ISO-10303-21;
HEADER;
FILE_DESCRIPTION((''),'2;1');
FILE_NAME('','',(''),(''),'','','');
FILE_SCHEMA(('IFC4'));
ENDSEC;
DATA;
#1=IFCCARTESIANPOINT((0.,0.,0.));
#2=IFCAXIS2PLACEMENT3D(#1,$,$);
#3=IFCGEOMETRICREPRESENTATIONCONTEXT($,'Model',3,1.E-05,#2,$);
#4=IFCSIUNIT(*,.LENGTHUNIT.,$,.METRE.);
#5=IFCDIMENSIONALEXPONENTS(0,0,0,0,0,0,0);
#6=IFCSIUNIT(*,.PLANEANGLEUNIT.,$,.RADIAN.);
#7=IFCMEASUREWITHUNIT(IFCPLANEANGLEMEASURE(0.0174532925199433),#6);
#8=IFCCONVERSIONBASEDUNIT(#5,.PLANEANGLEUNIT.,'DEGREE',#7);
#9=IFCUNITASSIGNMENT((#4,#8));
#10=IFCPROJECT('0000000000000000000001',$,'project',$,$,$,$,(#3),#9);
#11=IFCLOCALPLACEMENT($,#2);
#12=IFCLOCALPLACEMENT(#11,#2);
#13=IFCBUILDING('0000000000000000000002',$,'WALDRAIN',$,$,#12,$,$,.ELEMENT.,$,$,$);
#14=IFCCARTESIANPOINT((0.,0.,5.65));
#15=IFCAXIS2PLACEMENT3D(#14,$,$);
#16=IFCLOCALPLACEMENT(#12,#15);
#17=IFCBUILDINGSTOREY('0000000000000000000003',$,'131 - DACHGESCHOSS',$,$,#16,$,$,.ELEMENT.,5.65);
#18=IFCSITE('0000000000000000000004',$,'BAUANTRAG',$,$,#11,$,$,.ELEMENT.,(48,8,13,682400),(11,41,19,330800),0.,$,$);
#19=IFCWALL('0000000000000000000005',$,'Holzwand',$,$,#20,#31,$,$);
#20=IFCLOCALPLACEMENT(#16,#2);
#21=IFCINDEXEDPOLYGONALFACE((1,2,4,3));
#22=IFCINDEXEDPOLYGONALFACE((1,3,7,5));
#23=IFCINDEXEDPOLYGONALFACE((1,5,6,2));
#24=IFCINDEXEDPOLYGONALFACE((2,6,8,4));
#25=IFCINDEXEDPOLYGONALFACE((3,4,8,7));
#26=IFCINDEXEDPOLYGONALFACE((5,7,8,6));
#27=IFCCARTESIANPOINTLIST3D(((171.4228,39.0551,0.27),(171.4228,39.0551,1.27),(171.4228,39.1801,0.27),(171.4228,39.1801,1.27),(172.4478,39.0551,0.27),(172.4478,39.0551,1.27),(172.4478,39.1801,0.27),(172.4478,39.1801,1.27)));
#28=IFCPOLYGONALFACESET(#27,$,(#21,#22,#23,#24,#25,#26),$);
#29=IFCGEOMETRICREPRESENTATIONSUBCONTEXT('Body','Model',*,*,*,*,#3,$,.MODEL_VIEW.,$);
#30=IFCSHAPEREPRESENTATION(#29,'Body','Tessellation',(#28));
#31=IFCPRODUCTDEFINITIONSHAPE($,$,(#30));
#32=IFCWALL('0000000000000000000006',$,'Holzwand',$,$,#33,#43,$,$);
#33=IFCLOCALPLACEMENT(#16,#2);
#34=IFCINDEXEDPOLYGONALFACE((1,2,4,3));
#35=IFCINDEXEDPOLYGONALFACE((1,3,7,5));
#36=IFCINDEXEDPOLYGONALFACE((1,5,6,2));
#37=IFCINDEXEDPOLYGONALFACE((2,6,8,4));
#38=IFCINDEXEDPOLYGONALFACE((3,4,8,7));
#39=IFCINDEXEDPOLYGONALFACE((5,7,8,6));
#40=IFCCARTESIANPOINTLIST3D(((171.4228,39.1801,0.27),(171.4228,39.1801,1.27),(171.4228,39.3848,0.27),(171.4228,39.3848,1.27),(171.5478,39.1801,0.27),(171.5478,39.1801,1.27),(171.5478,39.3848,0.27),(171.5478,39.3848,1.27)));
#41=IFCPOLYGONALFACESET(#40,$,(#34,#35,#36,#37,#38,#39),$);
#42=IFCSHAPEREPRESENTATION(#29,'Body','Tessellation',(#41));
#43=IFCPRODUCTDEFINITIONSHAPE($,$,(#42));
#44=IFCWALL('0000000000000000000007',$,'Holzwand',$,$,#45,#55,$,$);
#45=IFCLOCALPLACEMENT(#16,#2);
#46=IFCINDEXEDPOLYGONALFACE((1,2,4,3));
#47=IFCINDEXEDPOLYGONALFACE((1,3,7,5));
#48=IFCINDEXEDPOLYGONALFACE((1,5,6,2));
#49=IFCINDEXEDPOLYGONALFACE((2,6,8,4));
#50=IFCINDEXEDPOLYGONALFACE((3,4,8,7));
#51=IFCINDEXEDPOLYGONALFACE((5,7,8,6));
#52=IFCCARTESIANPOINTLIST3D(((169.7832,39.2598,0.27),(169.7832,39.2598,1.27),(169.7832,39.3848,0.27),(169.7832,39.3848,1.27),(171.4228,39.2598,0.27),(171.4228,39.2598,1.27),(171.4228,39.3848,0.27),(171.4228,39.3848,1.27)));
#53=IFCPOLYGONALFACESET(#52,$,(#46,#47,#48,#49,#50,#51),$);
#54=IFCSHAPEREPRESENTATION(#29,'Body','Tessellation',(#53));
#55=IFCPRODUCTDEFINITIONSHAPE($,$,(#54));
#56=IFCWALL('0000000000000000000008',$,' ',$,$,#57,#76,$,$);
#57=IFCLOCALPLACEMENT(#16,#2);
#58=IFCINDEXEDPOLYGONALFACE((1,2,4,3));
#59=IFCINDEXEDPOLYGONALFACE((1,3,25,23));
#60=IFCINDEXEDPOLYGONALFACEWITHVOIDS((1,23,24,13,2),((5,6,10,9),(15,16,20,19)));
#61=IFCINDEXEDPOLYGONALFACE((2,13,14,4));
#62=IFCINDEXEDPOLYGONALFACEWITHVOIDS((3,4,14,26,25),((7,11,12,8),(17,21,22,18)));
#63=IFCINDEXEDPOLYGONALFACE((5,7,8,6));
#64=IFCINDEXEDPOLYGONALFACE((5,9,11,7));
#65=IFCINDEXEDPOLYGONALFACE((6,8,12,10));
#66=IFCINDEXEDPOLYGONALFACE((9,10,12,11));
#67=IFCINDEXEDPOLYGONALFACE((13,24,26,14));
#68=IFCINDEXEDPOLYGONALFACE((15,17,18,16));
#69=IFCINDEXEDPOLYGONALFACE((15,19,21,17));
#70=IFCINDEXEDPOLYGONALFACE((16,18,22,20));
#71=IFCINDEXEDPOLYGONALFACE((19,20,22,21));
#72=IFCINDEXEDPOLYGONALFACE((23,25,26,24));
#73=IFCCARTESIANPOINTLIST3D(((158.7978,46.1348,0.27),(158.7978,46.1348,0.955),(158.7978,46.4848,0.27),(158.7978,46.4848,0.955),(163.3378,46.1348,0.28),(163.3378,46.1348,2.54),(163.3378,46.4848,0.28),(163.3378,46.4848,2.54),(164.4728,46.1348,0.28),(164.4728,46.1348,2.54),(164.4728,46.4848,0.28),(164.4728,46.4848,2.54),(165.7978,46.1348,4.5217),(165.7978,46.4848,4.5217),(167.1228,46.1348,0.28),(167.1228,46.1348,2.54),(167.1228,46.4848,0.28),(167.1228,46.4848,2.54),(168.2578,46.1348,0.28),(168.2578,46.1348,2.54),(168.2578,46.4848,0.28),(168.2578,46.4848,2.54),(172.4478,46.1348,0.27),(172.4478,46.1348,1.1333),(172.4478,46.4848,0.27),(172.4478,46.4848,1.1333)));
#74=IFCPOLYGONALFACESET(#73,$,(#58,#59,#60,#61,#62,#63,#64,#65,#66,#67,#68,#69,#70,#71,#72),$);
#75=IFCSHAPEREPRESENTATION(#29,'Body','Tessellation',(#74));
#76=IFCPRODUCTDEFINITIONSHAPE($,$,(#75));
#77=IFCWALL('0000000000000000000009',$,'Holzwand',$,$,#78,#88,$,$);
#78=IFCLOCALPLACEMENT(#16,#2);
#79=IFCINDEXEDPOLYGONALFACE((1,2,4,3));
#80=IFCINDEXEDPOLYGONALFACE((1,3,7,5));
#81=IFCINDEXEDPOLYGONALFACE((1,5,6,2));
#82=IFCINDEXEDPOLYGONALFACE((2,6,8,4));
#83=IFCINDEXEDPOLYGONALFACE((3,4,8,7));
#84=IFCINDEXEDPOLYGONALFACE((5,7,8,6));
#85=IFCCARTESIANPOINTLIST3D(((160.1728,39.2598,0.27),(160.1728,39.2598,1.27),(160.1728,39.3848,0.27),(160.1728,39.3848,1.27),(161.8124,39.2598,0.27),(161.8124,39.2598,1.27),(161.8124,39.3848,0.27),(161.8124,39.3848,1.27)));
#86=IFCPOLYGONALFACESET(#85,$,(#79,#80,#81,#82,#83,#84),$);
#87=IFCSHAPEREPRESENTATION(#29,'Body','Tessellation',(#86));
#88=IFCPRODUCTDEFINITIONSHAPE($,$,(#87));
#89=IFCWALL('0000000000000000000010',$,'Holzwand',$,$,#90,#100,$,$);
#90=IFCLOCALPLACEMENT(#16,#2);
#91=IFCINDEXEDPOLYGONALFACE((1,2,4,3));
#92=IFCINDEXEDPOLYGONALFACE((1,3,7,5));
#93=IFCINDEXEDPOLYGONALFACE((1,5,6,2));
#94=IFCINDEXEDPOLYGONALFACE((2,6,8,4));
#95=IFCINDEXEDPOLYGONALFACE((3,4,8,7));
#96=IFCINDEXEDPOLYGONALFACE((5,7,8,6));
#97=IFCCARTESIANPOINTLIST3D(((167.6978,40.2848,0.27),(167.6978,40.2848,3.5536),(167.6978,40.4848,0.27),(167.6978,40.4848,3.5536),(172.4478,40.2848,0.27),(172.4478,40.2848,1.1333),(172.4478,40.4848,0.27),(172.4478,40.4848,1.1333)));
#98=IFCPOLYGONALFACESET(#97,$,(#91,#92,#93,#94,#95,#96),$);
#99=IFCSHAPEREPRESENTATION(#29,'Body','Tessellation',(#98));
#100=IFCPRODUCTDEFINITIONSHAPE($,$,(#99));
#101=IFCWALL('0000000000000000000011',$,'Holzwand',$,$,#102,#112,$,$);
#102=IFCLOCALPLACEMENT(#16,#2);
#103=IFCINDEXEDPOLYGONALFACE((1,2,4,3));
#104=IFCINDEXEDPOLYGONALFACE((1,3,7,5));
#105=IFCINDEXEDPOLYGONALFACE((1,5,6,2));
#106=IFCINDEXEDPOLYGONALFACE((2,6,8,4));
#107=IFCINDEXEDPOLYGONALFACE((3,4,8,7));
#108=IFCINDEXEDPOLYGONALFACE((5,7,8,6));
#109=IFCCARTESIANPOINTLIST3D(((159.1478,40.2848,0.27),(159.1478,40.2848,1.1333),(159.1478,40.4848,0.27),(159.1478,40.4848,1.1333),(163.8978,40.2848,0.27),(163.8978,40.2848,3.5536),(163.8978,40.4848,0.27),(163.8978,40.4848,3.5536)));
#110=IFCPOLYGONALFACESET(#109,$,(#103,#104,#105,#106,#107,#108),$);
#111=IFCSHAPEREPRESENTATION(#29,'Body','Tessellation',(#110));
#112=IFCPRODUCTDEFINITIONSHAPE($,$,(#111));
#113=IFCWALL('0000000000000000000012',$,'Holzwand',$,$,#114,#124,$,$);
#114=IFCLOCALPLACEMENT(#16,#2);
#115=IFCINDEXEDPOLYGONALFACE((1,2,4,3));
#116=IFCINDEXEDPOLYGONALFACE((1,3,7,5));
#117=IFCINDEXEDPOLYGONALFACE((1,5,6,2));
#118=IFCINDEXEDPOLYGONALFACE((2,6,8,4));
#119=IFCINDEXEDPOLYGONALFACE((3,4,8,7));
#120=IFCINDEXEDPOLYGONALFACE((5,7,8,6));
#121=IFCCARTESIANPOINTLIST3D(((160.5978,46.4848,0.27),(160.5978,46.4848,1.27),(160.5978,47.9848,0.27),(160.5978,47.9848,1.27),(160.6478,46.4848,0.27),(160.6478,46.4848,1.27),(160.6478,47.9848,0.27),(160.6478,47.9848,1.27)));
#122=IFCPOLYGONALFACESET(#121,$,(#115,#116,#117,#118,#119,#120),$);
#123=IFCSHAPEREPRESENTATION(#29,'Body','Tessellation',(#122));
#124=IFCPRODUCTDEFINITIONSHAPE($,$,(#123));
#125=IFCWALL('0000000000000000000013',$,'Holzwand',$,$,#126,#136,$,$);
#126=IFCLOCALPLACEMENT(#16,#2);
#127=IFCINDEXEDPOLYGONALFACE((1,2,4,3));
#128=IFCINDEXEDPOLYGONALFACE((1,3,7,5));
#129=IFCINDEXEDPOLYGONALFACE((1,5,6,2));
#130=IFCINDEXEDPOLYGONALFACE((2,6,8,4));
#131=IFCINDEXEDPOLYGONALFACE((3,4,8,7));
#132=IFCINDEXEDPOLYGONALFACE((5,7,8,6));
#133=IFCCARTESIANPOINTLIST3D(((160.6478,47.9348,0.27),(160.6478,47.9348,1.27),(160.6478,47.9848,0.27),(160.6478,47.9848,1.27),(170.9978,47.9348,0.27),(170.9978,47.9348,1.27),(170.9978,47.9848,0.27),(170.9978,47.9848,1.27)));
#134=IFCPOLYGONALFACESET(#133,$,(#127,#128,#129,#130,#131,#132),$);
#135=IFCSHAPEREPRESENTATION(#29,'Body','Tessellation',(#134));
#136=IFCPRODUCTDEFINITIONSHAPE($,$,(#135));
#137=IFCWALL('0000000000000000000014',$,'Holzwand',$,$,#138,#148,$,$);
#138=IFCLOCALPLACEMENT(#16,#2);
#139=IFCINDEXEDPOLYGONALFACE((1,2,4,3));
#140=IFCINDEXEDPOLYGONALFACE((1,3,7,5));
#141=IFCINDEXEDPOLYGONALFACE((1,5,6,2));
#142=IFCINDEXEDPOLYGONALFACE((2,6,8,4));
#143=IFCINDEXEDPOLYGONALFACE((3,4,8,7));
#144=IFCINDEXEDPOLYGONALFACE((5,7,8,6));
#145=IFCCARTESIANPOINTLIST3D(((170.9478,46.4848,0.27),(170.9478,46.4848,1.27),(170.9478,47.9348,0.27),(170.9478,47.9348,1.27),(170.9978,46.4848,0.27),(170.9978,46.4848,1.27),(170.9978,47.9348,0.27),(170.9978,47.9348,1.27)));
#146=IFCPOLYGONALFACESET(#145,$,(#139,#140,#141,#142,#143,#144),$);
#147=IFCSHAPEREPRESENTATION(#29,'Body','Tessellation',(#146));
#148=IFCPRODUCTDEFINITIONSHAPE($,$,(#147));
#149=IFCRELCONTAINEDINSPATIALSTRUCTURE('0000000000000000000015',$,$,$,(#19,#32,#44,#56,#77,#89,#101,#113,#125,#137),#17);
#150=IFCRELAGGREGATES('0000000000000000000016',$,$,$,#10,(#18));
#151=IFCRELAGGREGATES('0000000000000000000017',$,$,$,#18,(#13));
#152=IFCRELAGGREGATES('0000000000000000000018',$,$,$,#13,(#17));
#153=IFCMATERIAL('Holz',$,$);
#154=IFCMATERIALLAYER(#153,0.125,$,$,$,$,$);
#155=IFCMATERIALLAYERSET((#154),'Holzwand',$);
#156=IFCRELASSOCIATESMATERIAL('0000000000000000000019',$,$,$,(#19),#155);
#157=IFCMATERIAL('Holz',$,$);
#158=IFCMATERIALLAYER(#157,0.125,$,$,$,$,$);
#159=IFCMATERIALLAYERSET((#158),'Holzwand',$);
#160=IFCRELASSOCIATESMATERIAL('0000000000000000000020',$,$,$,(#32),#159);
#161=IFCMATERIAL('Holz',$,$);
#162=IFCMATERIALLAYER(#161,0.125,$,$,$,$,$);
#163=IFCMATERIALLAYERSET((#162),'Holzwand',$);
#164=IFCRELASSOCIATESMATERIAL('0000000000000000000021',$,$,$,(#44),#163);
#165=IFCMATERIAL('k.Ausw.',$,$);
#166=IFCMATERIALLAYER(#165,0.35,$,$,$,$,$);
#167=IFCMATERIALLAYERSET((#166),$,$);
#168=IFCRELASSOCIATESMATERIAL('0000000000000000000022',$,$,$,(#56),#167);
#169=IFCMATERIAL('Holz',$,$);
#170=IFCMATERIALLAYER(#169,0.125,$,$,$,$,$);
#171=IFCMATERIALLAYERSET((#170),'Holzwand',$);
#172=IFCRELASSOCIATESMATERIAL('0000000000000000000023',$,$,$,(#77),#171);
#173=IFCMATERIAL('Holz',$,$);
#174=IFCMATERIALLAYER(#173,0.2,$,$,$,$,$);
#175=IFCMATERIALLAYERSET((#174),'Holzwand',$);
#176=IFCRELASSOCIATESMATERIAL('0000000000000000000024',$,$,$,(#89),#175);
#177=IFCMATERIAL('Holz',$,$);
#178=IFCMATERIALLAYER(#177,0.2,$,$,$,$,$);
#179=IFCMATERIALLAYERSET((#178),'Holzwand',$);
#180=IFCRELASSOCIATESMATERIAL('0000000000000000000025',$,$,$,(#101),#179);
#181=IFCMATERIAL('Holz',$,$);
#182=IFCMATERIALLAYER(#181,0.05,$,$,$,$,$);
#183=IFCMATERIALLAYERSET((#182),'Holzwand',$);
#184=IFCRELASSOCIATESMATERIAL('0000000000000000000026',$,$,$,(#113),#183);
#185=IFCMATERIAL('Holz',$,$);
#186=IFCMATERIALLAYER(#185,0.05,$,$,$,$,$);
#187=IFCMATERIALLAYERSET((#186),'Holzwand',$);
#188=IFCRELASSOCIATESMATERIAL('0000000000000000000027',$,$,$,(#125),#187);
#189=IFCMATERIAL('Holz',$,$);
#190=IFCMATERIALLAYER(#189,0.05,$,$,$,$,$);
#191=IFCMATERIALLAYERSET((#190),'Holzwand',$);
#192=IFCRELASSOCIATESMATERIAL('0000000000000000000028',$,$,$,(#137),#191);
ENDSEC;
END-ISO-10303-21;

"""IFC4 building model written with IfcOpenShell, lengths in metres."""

from ifc_helpers import new_model, entity, si_unit, converted_unit, frame, frame_2d, origin, origin_with_axes, place, context, subcontext, project, spatial, polyline, rectangle, outline, extrude, clip, halfspace, bounded_halfspace, material, layer, layer_set, layer_usage, element, save


model = new_model("IFC4")

# Units and contexts
model_context = context("Model", 3, precision=1e-05, world=origin())
body_context = subcontext(model_context, "Body", "Model", "MODEL_VIEW")
ifc_project = project(units=[si_unit("LENGTHUNIT", "METRE"), converted_unit("PLANEANGLEUNIT", "DEGREE", entity("IfcPlaneAngleMeasure", 0.0174532925199433), si_unit("PLANEANGLEUNIT", "RADIAN"), dimensions=[0, 0, 0, 0, 0, 0, 0])], contexts=[model_context])

# Site, building, storey
site_placement = place(None, origin())
site = spatial("IfcSite", under=ifc_project, at=site_placement, Name="BAUANTRAG", CompositionType="ELEMENT", RefLatitude=(48, 8, 13, 682400), RefLongitude=(11, 41, 19, 330800), RefElevation=0.0)
building_placement = place(site_placement, origin())
building = spatial("IfcBuilding", under=site, at=building_placement, Name="WALDRAIN", CompositionType="ELEMENT")
storey_placement = place(building_placement, frame((0.0, 0.0, 5.65)))
storey = spatial("IfcBuildingStorey", under=building, at=storey_placement, Name="131 - DACHGESCHOSS", CompositionType="ELEMENT", Elevation=5.65)

# Walls
ifc_material_1 = material(Name="Holz")
ifc_layer_1 = layer(ifc_material_1, 0.125)
ifc_layer_set_1 = layer_set([ifc_layer_1], Name="Holzwand")
ifc_layer_usage_1 = layer_usage(ifc_layer_set_1, "AXIS2", "POSITIVE", 0.0)
wall_1_placement = place(storey_placement, frame((172.4478, 39.1801, 0.27), z_axis=(0.0, 0.0, 1.0), x_axis=(-1.0, 0.0, 0.0)))
element("IfcWall", 1, at=wall_1_placement, inside=storey, material=ifc_layer_usage_1, Name="Holzwand", context=body_context, shape_type="SweptSolid", body=[
    extrude(rectangle(XDim=1.025, YDim=0.125, at=frame_2d((0.5125, 0.0625), x_axis=(1.0, 0.0))), origin_with_axes(), (0.0, 0.0, 1.0), 1.0),
])
ifc_material_2 = material(Name="Holz")
ifc_layer_2 = layer(ifc_material_2, 0.125)
ifc_layer_set_2 = layer_set([ifc_layer_2], Name="Holzwand")
ifc_layer_usage_2 = layer_usage(ifc_layer_set_2, "AXIS2", "POSITIVE", 0.0)
wall_2_placement = place(storey_placement, frame((171.5478, 39.1801, 0.27), z_axis=(0.0, 0.0, 1.0), x_axis=(0.0, 1.0, 0.0)))
element("IfcWall", 2, at=wall_2_placement, inside=storey, material=ifc_layer_usage_2, Name="Holzwand", context=body_context, shape_type="SweptSolid", body=[
    extrude(rectangle(XDim=0.2047, YDim=0.125, at=frame_2d((0.1024, 0.0625), x_axis=(1.0, 0.0))), origin_with_axes(), (0.0, 0.0, 1.0), 1.0),
])
ifc_material_3 = material(Name="Holz")
ifc_layer_3 = layer(ifc_material_3, 0.125)
ifc_layer_set_3 = layer_set([ifc_layer_3], Name="Holzwand")
ifc_layer_usage_3 = layer_usage(ifc_layer_set_3, "AXIS2", "POSITIVE", 0.0)
wall_3_placement = place(storey_placement, frame((171.4228, 39.3848, 0.27), z_axis=(0.0, 0.0, 1.0), x_axis=(-1.0, 0.0, 0.0)))
element("IfcWall", 3, at=wall_3_placement, inside=storey, material=ifc_layer_usage_3, Name="Holzwand", context=body_context, shape_type="SweptSolid", body=[
    extrude(rectangle(XDim=1.6396, YDim=0.125, at=frame_2d((0.8198, 0.0625), x_axis=(1.0, 0.0))), origin_with_axes(), (0.0, 0.0, 1.0), 1.0),
])

# Wall, openings
ifc_material_4 = material(Name="k.Ausw.")
ifc_layer_4 = layer(ifc_material_4, 0.35)
ifc_layer_set_4 = layer_set([ifc_layer_4])
ifc_layer_usage_4 = layer_usage(ifc_layer_set_4, "AXIS2", "POSITIVE", 0.0)
wall_4_placement = place(storey_placement, frame((172.4478, 46.4848, 0.27), z_axis=(0.0, 0.0, 1.0), x_axis=(-1.0, 0.0, 0.0)))
wall_4 = element("IfcWall", 4, at=wall_4_placement, inside=storey, material=ifc_layer_usage_4, Name=" ", context=body_context, shape_type="Clipping", body=[
    clip(clip(extrude(rectangle(XDim=13.65, YDim=0.35, at=frame_2d((6.825, 0.175), x_axis=(1.0, 0.0))), origin_with_axes(), (0.0, 0.0, 1.0), 4.2517), bounded_halfspace(frame((10.15, 0.175, 2.4683), z_axis=(-0.45399, 0.0, -0.891007), x_axis=(0.0, -1.0, 0.0)), True, origin_with_axes(), polyline([(6.65, 0.35), (6.65, 0.0), (13.65, 0.0), (13.65, 0.35), (6.65, 0.35)]))), bounded_halfspace(frame((3.325, 0.175, 2.5575), z_axis=(0.45399, 0.0, -0.891007), x_axis=(0.0, -1.0, 0.0)), True, origin_with_axes(), polyline([(0.0, 0.35), (0.0, 0.0), (6.65, 0.0), (6.65, 0.35), (0.0, 0.35)]))),
])
opening_1_placement = place(wall_4_placement, frame((9.11, 0.35, 0.01), z_axis=(0.0, -1.0, 0.0), x_axis=(0.0, 0.0, 1.0)))
element("IfcOpeningElement", 5, at=opening_1_placement, cuts=wall_4, ObjectType="Opening", context=body_context, shape_type="SweptSolid", body=[
    extrude(outline(polyline([(0.0, 1.135), (2.26, 1.135), (2.26, 0.0), (0.0, 0.0), (0.0, 1.135)])), origin_with_axes(), (0.0, 0.0, 1.0), 0.35),
])
opening_2_placement = place(wall_4_placement, frame((5.325, 0.35, 0.01), z_axis=(0.0, -1.0, 0.0), x_axis=(0.0, 0.0, 1.0)))
element("IfcOpeningElement", 6, at=opening_2_placement, cuts=wall_4, ObjectType="Opening", context=body_context, shape_type="SweptSolid", body=[
    extrude(outline(polyline([(0.0, 1.135), (2.26, 1.135), (2.26, 0.0), (0.0, 0.0), (0.0, 1.135)])), origin_with_axes(), (0.0, 0.0, 1.0), 0.35),
])

# Walls
ifc_material_5 = material(Name="Holz")
ifc_layer_5 = layer(ifc_material_5, 0.125)
ifc_layer_set_5 = layer_set([ifc_layer_5], Name="Holzwand")
ifc_layer_usage_5 = layer_usage(ifc_layer_set_5, "AXIS2", "POSITIVE", 0.0)
wall_5_placement = place(storey_placement, frame((161.8124, 39.3848, 0.27), z_axis=(0.0, 0.0, 1.0), x_axis=(-1.0, 0.0, 0.0)))
element("IfcWall", 7, at=wall_5_placement, inside=storey, material=ifc_layer_usage_5, Name="Holzwand", context=body_context, shape_type="SweptSolid", body=[
    extrude(rectangle(XDim=1.6396, YDim=0.125, at=frame_2d((0.8198, 0.0625), x_axis=(1.0, 0.0))), origin_with_axes(), (0.0, 0.0, 1.0), 1.0),
])
ifc_material_6 = material(Name="Holz")
ifc_layer_6 = layer(ifc_material_6, 0.2)
ifc_layer_set_6 = layer_set([ifc_layer_6], Name="Holzwand")
ifc_layer_usage_6 = layer_usage(ifc_layer_set_6, "AXIS2", "POSITIVE", 0.0)
wall_6_placement = place(storey_placement, frame((172.4478, 40.4848, 0.27), z_axis=(0.0, 0.0, 1.0), x_axis=(-1.0, 0.0, 0.0)))
element("IfcWall", 8, at=wall_6_placement, inside=storey, material=ifc_layer_usage_6, Name="Holzwand", context=body_context, shape_type="Clipping", body=[
    clip(extrude(rectangle(XDim=4.75, YDim=0.2, at=frame_2d((2.375, 0.1), x_axis=(1.0, 0.0))), origin_with_axes(), (0.0, 0.0, 1.0), 3.2836), halfspace(frame((2.375, 0.1, 2.0735), z_axis=(0.45399, 0.0, -0.891007), x_axis=(0.891007, 0.0, 0.45399)), True)),
])
ifc_material_7 = material(Name="Holz")
ifc_layer_7 = layer(ifc_material_7, 0.2)
ifc_layer_set_7 = layer_set([ifc_layer_7], Name="Holzwand")
ifc_layer_usage_7 = layer_usage(ifc_layer_set_7, "AXIS2", "POSITIVE", 0.0)
wall_7_placement = place(storey_placement, frame((163.8978, 40.4848, 0.27), z_axis=(0.0, 0.0, 1.0), x_axis=(-1.0, 0.0, 0.0)))
element("IfcWall", 9, at=wall_7_placement, inside=storey, material=ifc_layer_usage_7, Name="Holzwand", context=body_context, shape_type="Clipping", body=[
    clip(extrude(rectangle(XDim=4.75, YDim=0.2, at=frame_2d((2.375, 0.1), x_axis=(1.0, 0.0))), origin_with_axes(), (0.0, 0.0, 1.0), 3.2836), halfspace(frame((2.375, 0.1, 2.0735), z_axis=(-0.45399, 0.0, -0.891007), x_axis=(0.891007, 0.0, -0.45399)), True)),
])
ifc_material_8 = material(Name="Holz")
ifc_layer_8 = layer(ifc_material_8, 0.05)
ifc_layer_set_8 = layer_set([ifc_layer_8], Name="Holzwand")
ifc_layer_usage_8 = layer_usage(ifc_layer_set_8, "AXIS2", "POSITIVE", 0.0)
wall_8_placement = place(storey_placement, frame((160.5978, 47.9848, 0.27), z_axis=(0.0, 0.0, 1.0), x_axis=(0.0, -1.0, 0.0)))
element("IfcWall", 10, at=wall_8_placement, inside=storey, material=ifc_layer_usage_8, Name="Holzwand", context=body_context, shape_type="SweptSolid", body=[
    extrude(rectangle(XDim=1.5, YDim=0.05, at=frame_2d((0.75, 0.025), x_axis=(1.0, 0.0))), origin_with_axes(), (0.0, 0.0, 1.0), 1.0),
])
ifc_material_9 = material(Name="Holz")
ifc_layer_9 = layer(ifc_material_9, 0.05)
ifc_layer_set_9 = layer_set([ifc_layer_9], Name="Holzwand")
ifc_layer_usage_9 = layer_usage(ifc_layer_set_9, "AXIS2", "POSITIVE", 0.0)
wall_9_placement = place(storey_placement, frame((170.9978, 47.9848, 0.27), z_axis=(0.0, 0.0, 1.0), x_axis=(-1.0, 0.0, 0.0)))
element("IfcWall", 11, at=wall_9_placement, inside=storey, material=ifc_layer_usage_9, Name="Holzwand", context=body_context, shape_type="SweptSolid", body=[
    extrude(rectangle(XDim=10.35, YDim=0.05, at=frame_2d((5.175, 0.025), x_axis=(1.0, 0.0))), origin_with_axes(), (0.0, 0.0, 1.0), 1.0),
])
ifc_material_10 = material(Name="Holz")
ifc_layer_10 = layer(ifc_material_10, 0.05)
ifc_layer_set_10 = layer_set([ifc_layer_10], Name="Holzwand")
ifc_layer_usage_10 = layer_usage(ifc_layer_set_10, "AXIS2", "POSITIVE", 0.0)
wall_10_placement = place(storey_placement, frame((170.9978, 46.4848, 0.27), z_axis=(0.0, 0.0, 1.0), x_axis=(0.0, 1.0, 0.0)))
element("IfcWall", 12, at=wall_10_placement, inside=storey, material=ifc_layer_usage_10, Name="Holzwand", context=body_context, shape_type="SweptSolid", body=[
    extrude(rectangle(XDim=1.45, YDim=0.05, at=frame_2d((0.725, 0.025), x_axis=(1.0, 0.0))), origin_with_axes(), (0.0, 0.0, 1.0), 1.0),
])

save(model, "model.ifc")
